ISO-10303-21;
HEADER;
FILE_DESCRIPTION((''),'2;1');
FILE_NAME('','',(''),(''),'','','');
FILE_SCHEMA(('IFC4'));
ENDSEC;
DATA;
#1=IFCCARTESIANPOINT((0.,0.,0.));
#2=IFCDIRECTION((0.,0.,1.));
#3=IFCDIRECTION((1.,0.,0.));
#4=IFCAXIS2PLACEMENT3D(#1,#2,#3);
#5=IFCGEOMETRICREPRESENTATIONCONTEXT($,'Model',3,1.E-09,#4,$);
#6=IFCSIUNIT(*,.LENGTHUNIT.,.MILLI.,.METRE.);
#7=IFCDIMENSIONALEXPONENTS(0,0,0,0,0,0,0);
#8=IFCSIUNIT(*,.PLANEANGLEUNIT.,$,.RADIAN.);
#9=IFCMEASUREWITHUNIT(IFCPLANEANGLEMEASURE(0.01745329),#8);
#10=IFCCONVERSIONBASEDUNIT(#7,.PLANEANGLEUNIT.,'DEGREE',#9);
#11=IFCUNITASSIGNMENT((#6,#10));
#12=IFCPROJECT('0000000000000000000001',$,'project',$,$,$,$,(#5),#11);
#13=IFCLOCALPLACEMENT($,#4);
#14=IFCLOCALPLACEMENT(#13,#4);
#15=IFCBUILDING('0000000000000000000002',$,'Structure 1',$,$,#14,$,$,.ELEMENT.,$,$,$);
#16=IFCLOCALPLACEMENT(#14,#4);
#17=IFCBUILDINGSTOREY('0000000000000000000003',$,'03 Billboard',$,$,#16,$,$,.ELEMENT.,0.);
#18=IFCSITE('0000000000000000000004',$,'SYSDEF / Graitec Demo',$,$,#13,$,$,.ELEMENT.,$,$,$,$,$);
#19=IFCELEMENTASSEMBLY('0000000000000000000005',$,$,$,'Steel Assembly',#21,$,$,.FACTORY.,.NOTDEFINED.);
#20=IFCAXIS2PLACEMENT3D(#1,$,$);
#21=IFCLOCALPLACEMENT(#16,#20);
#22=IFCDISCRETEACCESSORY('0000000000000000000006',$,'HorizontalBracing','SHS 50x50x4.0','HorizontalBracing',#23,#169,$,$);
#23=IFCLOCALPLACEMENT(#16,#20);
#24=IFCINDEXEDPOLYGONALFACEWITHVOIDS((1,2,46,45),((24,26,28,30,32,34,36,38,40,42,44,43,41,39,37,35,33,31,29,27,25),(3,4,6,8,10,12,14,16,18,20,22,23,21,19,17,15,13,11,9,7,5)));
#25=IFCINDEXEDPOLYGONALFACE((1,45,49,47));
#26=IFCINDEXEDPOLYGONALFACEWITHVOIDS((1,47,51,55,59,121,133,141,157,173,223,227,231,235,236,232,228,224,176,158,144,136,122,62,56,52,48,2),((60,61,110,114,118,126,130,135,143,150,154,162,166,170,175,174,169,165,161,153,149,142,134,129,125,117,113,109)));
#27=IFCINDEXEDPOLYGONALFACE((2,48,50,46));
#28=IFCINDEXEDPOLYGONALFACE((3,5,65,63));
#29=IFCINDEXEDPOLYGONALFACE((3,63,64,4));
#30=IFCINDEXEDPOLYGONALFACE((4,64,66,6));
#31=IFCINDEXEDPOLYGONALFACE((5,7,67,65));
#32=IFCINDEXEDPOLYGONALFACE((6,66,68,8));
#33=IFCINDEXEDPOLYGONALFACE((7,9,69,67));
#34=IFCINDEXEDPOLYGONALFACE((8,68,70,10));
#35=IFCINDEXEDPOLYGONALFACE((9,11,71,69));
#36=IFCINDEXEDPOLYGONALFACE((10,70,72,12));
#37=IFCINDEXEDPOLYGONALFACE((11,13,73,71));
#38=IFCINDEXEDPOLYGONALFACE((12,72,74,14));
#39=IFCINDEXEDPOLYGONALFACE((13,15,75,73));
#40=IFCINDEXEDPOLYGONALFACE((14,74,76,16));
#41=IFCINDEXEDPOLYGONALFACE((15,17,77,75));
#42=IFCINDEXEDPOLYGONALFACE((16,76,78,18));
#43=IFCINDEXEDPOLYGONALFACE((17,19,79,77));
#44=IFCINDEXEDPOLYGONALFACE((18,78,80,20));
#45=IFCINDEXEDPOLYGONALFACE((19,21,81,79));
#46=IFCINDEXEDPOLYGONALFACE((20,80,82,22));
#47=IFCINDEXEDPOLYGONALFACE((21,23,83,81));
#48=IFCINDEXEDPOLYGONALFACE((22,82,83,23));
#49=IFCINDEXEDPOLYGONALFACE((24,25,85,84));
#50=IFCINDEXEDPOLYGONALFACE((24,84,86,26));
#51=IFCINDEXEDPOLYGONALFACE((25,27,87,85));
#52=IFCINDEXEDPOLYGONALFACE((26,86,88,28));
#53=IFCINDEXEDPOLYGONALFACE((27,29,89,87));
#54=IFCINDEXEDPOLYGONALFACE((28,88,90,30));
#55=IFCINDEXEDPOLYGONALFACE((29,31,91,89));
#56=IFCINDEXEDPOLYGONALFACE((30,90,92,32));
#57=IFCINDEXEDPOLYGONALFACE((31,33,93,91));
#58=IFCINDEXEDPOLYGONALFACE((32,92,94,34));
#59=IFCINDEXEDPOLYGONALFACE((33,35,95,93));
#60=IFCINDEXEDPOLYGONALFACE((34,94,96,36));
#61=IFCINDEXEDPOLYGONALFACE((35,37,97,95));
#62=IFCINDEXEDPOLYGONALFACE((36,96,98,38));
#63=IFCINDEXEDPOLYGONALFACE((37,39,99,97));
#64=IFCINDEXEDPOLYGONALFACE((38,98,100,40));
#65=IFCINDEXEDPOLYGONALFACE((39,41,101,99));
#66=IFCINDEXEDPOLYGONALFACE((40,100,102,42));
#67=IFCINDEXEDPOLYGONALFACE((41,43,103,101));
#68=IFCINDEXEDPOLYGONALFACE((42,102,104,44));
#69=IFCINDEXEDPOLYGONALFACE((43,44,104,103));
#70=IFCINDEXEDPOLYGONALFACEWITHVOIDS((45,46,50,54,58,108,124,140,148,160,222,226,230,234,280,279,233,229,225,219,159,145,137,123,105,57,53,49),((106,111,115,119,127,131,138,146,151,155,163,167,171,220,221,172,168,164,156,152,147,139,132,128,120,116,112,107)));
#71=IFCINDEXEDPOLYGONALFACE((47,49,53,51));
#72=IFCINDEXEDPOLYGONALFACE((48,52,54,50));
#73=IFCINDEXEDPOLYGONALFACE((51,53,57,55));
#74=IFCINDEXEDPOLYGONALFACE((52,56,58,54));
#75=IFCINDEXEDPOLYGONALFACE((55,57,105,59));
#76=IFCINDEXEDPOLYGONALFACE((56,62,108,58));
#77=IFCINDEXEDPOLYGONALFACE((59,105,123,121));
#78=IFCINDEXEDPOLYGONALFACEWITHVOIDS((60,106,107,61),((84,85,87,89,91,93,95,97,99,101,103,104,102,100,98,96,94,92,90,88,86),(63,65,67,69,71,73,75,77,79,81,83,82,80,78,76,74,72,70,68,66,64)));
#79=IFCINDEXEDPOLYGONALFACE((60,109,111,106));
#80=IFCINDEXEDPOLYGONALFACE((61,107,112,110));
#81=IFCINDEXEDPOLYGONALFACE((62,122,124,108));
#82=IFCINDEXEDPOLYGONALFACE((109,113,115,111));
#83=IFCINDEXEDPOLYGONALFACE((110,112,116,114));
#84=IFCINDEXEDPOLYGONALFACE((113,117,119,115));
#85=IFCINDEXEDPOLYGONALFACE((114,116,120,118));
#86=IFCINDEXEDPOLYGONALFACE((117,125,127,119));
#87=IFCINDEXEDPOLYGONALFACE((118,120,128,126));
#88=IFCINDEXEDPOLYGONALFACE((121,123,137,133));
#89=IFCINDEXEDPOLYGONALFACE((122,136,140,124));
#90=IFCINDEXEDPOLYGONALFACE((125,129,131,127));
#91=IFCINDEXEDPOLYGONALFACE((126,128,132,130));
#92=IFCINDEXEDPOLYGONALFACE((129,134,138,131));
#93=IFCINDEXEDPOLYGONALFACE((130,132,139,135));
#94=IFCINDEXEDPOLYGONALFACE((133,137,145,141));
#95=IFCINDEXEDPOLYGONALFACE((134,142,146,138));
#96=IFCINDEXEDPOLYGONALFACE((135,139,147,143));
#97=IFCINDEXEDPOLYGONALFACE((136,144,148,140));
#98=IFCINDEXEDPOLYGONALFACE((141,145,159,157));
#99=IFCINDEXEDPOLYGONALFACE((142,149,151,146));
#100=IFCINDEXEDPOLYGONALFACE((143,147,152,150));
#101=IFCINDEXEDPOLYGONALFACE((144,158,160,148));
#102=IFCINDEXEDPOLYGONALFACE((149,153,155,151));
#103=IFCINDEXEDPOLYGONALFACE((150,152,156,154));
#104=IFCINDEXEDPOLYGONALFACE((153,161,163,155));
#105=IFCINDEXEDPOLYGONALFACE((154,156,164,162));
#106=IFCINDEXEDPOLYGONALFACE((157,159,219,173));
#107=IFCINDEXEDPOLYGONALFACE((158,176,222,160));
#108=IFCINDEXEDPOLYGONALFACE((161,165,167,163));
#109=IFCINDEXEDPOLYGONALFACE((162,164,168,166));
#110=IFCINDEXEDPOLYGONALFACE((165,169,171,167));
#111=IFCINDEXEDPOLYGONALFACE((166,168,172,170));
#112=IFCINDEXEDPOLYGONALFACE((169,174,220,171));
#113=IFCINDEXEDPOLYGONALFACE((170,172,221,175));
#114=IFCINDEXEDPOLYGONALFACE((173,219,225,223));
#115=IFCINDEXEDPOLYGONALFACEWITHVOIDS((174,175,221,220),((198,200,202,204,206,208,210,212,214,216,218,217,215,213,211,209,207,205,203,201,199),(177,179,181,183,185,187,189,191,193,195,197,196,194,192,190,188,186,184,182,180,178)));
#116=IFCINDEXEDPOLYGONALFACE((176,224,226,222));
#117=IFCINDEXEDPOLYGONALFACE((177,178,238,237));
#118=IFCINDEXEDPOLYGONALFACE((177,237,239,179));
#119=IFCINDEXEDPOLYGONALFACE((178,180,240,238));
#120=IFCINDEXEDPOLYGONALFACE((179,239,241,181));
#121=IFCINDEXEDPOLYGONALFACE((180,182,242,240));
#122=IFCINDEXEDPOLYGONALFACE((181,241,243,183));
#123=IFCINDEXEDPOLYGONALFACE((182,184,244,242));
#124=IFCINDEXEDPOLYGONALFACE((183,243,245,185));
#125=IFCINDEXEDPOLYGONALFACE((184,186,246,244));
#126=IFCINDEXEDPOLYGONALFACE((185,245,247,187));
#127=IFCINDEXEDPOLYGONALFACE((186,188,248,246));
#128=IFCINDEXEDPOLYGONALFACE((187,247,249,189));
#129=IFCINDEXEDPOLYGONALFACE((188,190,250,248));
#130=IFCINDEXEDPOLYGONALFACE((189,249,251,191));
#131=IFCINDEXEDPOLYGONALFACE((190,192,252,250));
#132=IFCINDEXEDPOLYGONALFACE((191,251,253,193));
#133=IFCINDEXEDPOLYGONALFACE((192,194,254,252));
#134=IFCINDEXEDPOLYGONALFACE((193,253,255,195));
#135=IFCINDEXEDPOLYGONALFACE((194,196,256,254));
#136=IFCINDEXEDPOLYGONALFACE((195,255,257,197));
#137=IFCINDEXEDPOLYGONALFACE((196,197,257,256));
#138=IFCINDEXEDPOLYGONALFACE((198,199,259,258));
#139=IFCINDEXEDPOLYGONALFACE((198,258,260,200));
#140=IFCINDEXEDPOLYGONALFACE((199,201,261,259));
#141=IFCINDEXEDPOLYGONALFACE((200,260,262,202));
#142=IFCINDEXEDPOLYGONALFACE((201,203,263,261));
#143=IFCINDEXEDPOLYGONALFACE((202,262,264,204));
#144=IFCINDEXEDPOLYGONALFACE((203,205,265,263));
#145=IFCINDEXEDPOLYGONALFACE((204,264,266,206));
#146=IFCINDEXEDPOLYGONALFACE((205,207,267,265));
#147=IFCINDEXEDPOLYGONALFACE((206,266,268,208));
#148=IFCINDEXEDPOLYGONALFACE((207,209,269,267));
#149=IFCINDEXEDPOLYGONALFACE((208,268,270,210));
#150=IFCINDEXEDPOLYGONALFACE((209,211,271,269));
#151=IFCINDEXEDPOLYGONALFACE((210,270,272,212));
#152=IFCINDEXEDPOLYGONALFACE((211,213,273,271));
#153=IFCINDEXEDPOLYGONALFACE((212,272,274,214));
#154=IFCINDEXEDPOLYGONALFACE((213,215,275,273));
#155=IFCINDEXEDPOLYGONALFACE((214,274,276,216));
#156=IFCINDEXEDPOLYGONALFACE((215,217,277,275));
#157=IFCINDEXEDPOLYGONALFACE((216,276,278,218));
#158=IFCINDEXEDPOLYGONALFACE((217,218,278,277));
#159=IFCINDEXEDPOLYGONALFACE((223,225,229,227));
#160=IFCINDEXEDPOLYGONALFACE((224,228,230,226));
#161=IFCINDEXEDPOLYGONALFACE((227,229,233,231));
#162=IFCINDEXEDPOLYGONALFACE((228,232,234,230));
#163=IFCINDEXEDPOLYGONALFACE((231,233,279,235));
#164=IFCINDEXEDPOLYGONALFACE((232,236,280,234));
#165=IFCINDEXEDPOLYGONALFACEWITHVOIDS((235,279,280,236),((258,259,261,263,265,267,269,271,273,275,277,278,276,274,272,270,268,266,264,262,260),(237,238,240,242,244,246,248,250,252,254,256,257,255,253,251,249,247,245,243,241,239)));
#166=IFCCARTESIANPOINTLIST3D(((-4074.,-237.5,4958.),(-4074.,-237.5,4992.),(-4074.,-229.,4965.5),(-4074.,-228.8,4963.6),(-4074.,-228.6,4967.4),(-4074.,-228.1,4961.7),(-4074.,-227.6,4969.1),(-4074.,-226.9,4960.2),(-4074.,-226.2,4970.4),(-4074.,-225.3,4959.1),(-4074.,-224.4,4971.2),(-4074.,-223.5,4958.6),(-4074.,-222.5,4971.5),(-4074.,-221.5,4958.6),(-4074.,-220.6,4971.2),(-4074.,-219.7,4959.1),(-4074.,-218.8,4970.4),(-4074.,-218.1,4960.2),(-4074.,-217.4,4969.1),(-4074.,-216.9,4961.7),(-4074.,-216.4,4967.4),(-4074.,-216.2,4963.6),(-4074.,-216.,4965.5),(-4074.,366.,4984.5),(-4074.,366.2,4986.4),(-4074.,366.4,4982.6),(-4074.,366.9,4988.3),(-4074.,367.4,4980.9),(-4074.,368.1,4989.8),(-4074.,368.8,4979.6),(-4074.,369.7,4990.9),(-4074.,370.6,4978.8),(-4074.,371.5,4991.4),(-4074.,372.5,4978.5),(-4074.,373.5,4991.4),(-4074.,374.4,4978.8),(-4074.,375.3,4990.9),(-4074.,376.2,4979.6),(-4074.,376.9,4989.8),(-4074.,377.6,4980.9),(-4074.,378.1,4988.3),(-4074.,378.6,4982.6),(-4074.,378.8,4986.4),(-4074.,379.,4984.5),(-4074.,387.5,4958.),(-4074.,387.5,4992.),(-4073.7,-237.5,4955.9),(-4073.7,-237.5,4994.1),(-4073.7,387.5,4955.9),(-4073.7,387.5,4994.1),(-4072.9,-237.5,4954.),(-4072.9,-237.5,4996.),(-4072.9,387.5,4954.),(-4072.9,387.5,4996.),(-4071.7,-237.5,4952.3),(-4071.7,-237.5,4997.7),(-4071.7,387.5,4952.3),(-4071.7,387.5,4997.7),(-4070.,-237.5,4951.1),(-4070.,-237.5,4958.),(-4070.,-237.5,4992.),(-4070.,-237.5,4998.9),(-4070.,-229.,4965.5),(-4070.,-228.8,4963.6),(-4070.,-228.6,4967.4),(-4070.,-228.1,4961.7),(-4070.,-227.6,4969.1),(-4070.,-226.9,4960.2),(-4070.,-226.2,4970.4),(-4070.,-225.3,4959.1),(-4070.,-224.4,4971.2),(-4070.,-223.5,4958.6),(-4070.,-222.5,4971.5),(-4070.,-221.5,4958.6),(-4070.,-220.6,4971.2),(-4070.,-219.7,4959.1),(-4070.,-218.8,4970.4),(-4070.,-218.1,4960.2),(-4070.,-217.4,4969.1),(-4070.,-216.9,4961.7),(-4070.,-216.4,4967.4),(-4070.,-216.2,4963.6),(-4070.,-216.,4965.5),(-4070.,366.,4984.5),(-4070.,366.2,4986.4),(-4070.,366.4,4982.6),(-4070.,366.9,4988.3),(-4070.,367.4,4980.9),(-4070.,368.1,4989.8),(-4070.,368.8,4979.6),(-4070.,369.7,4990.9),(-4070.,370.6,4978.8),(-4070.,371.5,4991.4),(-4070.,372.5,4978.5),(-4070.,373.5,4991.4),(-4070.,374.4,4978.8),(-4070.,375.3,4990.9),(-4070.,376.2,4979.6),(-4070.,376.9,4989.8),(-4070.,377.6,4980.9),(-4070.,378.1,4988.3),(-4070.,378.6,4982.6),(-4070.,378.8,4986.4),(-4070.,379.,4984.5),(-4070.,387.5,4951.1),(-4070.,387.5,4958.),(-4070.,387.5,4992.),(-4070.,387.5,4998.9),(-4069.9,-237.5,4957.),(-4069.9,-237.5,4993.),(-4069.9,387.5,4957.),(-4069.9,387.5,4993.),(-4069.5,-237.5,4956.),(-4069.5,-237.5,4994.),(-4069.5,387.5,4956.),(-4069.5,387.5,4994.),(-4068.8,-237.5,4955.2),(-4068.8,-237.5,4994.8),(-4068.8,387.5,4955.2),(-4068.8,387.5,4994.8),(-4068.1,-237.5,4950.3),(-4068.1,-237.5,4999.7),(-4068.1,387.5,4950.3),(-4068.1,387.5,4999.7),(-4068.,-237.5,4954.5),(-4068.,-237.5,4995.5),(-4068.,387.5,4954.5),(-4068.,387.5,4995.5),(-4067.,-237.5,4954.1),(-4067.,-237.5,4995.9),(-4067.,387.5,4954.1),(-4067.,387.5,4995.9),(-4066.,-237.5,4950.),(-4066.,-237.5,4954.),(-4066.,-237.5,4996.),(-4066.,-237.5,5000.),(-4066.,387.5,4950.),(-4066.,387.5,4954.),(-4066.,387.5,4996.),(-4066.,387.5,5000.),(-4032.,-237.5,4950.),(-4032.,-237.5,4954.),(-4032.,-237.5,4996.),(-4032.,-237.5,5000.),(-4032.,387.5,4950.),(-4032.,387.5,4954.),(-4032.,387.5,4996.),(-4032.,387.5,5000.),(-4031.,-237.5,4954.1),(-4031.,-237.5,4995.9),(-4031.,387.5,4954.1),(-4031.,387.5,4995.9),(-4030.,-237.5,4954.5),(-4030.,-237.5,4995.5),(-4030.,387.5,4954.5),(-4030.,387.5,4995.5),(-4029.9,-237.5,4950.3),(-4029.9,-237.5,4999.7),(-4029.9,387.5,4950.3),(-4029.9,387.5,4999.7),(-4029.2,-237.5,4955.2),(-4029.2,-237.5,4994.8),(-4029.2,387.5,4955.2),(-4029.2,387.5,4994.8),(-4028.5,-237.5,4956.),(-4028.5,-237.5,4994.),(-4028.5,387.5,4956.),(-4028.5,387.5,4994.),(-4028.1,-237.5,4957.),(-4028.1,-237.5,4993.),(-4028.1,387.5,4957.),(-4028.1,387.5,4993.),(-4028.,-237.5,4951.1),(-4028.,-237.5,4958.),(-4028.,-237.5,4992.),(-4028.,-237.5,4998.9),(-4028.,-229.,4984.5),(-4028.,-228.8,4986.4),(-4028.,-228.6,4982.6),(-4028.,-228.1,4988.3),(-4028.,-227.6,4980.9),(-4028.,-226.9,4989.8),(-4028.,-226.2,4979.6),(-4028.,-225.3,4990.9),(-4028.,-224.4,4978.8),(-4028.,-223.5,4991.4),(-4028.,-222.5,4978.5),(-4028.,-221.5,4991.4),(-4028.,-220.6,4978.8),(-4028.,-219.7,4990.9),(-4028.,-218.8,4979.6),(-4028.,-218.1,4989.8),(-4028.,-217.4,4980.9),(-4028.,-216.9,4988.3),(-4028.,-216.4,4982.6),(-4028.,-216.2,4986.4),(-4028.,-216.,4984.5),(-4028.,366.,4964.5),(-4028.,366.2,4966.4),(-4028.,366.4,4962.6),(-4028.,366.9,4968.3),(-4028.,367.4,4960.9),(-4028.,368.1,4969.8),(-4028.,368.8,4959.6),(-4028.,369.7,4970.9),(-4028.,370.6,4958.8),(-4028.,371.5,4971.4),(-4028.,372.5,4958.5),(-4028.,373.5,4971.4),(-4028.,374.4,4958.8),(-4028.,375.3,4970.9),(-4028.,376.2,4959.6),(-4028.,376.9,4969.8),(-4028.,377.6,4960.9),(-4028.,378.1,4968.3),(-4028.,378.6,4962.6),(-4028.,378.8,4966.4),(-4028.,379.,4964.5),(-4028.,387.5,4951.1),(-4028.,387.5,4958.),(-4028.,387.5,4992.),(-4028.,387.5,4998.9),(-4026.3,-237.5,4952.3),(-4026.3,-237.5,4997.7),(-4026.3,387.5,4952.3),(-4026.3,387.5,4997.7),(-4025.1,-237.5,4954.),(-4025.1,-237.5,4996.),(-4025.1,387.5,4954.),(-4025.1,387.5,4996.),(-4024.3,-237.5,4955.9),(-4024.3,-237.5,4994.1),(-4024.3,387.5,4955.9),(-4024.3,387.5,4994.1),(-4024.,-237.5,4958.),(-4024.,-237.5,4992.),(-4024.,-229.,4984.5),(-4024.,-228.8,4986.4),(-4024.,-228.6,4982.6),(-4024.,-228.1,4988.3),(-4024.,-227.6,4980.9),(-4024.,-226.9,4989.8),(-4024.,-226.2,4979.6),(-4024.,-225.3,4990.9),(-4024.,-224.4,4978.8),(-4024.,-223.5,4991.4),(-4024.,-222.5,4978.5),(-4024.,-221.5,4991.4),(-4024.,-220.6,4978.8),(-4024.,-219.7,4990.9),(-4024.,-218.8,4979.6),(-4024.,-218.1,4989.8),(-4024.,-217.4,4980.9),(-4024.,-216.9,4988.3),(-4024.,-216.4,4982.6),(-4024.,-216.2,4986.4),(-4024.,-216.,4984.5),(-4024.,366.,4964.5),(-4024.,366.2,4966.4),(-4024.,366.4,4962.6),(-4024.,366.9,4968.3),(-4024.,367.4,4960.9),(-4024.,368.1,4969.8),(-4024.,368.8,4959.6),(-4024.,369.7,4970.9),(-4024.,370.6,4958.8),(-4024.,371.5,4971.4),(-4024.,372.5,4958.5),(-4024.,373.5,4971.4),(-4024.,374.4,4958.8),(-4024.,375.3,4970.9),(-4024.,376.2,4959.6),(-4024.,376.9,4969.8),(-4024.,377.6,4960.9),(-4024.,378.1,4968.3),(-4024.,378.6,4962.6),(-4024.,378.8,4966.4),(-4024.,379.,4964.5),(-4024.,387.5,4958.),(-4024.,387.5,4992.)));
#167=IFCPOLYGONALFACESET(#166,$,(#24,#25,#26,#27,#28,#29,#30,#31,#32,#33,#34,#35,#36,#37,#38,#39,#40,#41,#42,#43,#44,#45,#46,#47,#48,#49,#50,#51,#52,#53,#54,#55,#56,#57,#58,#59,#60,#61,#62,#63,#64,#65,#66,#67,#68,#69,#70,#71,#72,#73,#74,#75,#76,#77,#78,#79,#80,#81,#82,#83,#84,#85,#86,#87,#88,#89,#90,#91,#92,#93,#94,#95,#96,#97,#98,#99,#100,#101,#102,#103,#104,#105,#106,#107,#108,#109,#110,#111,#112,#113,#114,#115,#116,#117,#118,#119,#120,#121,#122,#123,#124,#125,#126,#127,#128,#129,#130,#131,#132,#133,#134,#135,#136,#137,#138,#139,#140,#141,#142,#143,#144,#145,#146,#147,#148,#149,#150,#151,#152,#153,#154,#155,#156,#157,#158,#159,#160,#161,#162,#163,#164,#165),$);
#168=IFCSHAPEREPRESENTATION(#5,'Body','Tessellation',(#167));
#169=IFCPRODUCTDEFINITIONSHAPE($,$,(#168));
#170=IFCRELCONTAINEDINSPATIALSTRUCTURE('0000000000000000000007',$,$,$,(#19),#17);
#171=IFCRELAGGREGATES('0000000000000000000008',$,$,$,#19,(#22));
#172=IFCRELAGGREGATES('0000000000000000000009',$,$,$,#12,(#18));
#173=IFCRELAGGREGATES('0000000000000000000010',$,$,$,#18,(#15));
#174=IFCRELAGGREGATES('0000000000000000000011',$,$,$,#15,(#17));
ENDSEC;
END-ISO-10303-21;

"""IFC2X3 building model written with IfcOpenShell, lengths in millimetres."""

from ifc_helpers import new_model, entity, si_unit, converted_unit, frame, frame_2d, origin, origin_with_axes, origin_2d, origin_2d_with_axis, place, context, project, spatial, hollow_rectangle, circle, extrude, clip, halfspace, element, aggregate, save


model = new_model("IFC2X3")

# Units and contexts
model_context = context("Model", 3, precision=1e-09, world=origin_with_axes())
ifc_project = project(units=[si_unit("LENGTHUNIT", "METRE", prefix="MILLI"), converted_unit("PLANEANGLEUNIT", "DEGREE", entity("IfcPlaneAngleMeasure", 0.01745329), si_unit("PLANEANGLEUNIT", "RADIAN"), dimensions=[0, 0, 0, 0, 0, 0, 0])], contexts=[model_context])

# Site, building, storey
site_placement = place(None, origin_with_axes())
site = spatial("IfcSite", under=ifc_project, at=site_placement, Name="SYSDEF / Graitec Demo", CompositionType="ELEMENT")
building_placement = place(site_placement, origin_with_axes())
building = spatial("IfcBuilding", under=site, at=building_placement, Name="Structure 1", CompositionType="ELEMENT")
storey_placement = place(building_placement, origin_with_axes())
storey = spatial("IfcBuildingStorey", under=building, at=storey_placement, Name="03 Billboard", CompositionType="ELEMENT", Elevation=0.0)

# Element assembly, discrete accessory, openings
assembly_placement = place(None, frame((-4239.1, -387.5, 4000.0), z_axis=(-1.0, 0.0, 0.0), x_axis=(0.0, 0.0, 1.0)))
assembly = element("IfcElementAssembly", 1, at=assembly_placement, inside=storey, ObjectType="Steel Assembly", AssemblyPlace="FACTORY", PredefinedType="NOTDEFINED")
discrete_accessory_1_placement = place(assembly_placement, frame((975.0, 27.1, -190.1), z_axis=(0.0, -1.0, 0.0), x_axis=(0.0, 0.0, -1.0)))
discrete_accessory_1 = element("IfcDiscreteAccessory", 2, at=discrete_accessory_1_placement, Name="HorizontalBracing", Description="SHS 50x50x4.0", ObjectType="HorizontalBracing", context=model_context, shape_type="Clipping", body=[
    clip(clip(extrude(hollow_rectangle(XDim=50.0, YDim=50.0, WallThickness=4.0, InnerFilletRadius=4.0, OuterFilletRadius=8.0, at=origin_2d()), origin(), (0.0, 0.0, -1.0), 883.2), halfspace(frame((4049.0, -4975.0, -747.9), z_axis=(0.0, 0.0, 1.0), x_axis=(1.0, 0.0, 0.0)), True)), halfspace(frame((4049.0, -4975.0, -122.9), z_axis=(0.0, 0.0, -1.0), x_axis=(-1.0, 0.0, 0.0)), True)),
])
opening_1_placement = place(discrete_accessory_1_placement, frame((20.5, -16.5, -732.9), z_axis=(-1.0, 0.0, 0.0), x_axis=(0.0, -1.0, 0.0)))
element("IfcOpeningElement", 3, at=opening_1_placement, cuts=discrete_accessory_1, ObjectType="Opening", context=model_context, shape_type="SweptSolid", body=[
    extrude(circle(Radius=6.5, at=frame_2d((-6.5, 0.0), x_axis=(1.0, 0.0))), origin(), (0.0, 0.0, -1.0), 5.0),
])
opening_2_placement = place(discrete_accessory_1_placement, frame((-25.5, 10.0, -732.9), z_axis=(1.0, 0.0, 0.0), x_axis=(0.0, -1.0, 0.0)))
element("IfcOpeningElement", 4, at=opening_2_placement, cuts=discrete_accessory_1, ObjectType="Opening", context=model_context, shape_type="SweptSolid", body=[
    extrude(circle(Radius=6.5, at=origin_2d_with_axis()), origin(), (0.0, 0.0, 1.0), 5.0),
])
opening_3_placement = place(discrete_accessory_1_placement, frame((20.5, 16.5, -137.9), z_axis=(-1.0, 0.0, 0.0), x_axis=(0.0, -1.0, 0.0)))
element("IfcOpeningElement", 5, at=opening_3_placement, cuts=discrete_accessory_1, ObjectType="Opening", context=model_context, shape_type="SweptSolid", body=[
    extrude(circle(Radius=6.5, at=frame_2d((6.5, 0.0), x_axis=(1.0, 0.0))), origin(), (0.0, 0.0, -1.0), 5.0),
])
opening_4_placement = place(discrete_accessory_1_placement, frame((-25.5, -10.0, -137.9), z_axis=(1.0, 0.0, 0.0), x_axis=(0.0, 1.0, 0.0)))
element("IfcOpeningElement", 6, at=opening_4_placement, cuts=discrete_accessory_1, ObjectType="Opening", context=model_context, shape_type="SweptSolid", body=[
    extrude(circle(Radius=6.5, at=origin_2d_with_axis()), origin(), (0.0, 0.0, 1.0), 5.0),
])
aggregate(assembly, [discrete_accessory_1])

save(model, "model.ifc")
